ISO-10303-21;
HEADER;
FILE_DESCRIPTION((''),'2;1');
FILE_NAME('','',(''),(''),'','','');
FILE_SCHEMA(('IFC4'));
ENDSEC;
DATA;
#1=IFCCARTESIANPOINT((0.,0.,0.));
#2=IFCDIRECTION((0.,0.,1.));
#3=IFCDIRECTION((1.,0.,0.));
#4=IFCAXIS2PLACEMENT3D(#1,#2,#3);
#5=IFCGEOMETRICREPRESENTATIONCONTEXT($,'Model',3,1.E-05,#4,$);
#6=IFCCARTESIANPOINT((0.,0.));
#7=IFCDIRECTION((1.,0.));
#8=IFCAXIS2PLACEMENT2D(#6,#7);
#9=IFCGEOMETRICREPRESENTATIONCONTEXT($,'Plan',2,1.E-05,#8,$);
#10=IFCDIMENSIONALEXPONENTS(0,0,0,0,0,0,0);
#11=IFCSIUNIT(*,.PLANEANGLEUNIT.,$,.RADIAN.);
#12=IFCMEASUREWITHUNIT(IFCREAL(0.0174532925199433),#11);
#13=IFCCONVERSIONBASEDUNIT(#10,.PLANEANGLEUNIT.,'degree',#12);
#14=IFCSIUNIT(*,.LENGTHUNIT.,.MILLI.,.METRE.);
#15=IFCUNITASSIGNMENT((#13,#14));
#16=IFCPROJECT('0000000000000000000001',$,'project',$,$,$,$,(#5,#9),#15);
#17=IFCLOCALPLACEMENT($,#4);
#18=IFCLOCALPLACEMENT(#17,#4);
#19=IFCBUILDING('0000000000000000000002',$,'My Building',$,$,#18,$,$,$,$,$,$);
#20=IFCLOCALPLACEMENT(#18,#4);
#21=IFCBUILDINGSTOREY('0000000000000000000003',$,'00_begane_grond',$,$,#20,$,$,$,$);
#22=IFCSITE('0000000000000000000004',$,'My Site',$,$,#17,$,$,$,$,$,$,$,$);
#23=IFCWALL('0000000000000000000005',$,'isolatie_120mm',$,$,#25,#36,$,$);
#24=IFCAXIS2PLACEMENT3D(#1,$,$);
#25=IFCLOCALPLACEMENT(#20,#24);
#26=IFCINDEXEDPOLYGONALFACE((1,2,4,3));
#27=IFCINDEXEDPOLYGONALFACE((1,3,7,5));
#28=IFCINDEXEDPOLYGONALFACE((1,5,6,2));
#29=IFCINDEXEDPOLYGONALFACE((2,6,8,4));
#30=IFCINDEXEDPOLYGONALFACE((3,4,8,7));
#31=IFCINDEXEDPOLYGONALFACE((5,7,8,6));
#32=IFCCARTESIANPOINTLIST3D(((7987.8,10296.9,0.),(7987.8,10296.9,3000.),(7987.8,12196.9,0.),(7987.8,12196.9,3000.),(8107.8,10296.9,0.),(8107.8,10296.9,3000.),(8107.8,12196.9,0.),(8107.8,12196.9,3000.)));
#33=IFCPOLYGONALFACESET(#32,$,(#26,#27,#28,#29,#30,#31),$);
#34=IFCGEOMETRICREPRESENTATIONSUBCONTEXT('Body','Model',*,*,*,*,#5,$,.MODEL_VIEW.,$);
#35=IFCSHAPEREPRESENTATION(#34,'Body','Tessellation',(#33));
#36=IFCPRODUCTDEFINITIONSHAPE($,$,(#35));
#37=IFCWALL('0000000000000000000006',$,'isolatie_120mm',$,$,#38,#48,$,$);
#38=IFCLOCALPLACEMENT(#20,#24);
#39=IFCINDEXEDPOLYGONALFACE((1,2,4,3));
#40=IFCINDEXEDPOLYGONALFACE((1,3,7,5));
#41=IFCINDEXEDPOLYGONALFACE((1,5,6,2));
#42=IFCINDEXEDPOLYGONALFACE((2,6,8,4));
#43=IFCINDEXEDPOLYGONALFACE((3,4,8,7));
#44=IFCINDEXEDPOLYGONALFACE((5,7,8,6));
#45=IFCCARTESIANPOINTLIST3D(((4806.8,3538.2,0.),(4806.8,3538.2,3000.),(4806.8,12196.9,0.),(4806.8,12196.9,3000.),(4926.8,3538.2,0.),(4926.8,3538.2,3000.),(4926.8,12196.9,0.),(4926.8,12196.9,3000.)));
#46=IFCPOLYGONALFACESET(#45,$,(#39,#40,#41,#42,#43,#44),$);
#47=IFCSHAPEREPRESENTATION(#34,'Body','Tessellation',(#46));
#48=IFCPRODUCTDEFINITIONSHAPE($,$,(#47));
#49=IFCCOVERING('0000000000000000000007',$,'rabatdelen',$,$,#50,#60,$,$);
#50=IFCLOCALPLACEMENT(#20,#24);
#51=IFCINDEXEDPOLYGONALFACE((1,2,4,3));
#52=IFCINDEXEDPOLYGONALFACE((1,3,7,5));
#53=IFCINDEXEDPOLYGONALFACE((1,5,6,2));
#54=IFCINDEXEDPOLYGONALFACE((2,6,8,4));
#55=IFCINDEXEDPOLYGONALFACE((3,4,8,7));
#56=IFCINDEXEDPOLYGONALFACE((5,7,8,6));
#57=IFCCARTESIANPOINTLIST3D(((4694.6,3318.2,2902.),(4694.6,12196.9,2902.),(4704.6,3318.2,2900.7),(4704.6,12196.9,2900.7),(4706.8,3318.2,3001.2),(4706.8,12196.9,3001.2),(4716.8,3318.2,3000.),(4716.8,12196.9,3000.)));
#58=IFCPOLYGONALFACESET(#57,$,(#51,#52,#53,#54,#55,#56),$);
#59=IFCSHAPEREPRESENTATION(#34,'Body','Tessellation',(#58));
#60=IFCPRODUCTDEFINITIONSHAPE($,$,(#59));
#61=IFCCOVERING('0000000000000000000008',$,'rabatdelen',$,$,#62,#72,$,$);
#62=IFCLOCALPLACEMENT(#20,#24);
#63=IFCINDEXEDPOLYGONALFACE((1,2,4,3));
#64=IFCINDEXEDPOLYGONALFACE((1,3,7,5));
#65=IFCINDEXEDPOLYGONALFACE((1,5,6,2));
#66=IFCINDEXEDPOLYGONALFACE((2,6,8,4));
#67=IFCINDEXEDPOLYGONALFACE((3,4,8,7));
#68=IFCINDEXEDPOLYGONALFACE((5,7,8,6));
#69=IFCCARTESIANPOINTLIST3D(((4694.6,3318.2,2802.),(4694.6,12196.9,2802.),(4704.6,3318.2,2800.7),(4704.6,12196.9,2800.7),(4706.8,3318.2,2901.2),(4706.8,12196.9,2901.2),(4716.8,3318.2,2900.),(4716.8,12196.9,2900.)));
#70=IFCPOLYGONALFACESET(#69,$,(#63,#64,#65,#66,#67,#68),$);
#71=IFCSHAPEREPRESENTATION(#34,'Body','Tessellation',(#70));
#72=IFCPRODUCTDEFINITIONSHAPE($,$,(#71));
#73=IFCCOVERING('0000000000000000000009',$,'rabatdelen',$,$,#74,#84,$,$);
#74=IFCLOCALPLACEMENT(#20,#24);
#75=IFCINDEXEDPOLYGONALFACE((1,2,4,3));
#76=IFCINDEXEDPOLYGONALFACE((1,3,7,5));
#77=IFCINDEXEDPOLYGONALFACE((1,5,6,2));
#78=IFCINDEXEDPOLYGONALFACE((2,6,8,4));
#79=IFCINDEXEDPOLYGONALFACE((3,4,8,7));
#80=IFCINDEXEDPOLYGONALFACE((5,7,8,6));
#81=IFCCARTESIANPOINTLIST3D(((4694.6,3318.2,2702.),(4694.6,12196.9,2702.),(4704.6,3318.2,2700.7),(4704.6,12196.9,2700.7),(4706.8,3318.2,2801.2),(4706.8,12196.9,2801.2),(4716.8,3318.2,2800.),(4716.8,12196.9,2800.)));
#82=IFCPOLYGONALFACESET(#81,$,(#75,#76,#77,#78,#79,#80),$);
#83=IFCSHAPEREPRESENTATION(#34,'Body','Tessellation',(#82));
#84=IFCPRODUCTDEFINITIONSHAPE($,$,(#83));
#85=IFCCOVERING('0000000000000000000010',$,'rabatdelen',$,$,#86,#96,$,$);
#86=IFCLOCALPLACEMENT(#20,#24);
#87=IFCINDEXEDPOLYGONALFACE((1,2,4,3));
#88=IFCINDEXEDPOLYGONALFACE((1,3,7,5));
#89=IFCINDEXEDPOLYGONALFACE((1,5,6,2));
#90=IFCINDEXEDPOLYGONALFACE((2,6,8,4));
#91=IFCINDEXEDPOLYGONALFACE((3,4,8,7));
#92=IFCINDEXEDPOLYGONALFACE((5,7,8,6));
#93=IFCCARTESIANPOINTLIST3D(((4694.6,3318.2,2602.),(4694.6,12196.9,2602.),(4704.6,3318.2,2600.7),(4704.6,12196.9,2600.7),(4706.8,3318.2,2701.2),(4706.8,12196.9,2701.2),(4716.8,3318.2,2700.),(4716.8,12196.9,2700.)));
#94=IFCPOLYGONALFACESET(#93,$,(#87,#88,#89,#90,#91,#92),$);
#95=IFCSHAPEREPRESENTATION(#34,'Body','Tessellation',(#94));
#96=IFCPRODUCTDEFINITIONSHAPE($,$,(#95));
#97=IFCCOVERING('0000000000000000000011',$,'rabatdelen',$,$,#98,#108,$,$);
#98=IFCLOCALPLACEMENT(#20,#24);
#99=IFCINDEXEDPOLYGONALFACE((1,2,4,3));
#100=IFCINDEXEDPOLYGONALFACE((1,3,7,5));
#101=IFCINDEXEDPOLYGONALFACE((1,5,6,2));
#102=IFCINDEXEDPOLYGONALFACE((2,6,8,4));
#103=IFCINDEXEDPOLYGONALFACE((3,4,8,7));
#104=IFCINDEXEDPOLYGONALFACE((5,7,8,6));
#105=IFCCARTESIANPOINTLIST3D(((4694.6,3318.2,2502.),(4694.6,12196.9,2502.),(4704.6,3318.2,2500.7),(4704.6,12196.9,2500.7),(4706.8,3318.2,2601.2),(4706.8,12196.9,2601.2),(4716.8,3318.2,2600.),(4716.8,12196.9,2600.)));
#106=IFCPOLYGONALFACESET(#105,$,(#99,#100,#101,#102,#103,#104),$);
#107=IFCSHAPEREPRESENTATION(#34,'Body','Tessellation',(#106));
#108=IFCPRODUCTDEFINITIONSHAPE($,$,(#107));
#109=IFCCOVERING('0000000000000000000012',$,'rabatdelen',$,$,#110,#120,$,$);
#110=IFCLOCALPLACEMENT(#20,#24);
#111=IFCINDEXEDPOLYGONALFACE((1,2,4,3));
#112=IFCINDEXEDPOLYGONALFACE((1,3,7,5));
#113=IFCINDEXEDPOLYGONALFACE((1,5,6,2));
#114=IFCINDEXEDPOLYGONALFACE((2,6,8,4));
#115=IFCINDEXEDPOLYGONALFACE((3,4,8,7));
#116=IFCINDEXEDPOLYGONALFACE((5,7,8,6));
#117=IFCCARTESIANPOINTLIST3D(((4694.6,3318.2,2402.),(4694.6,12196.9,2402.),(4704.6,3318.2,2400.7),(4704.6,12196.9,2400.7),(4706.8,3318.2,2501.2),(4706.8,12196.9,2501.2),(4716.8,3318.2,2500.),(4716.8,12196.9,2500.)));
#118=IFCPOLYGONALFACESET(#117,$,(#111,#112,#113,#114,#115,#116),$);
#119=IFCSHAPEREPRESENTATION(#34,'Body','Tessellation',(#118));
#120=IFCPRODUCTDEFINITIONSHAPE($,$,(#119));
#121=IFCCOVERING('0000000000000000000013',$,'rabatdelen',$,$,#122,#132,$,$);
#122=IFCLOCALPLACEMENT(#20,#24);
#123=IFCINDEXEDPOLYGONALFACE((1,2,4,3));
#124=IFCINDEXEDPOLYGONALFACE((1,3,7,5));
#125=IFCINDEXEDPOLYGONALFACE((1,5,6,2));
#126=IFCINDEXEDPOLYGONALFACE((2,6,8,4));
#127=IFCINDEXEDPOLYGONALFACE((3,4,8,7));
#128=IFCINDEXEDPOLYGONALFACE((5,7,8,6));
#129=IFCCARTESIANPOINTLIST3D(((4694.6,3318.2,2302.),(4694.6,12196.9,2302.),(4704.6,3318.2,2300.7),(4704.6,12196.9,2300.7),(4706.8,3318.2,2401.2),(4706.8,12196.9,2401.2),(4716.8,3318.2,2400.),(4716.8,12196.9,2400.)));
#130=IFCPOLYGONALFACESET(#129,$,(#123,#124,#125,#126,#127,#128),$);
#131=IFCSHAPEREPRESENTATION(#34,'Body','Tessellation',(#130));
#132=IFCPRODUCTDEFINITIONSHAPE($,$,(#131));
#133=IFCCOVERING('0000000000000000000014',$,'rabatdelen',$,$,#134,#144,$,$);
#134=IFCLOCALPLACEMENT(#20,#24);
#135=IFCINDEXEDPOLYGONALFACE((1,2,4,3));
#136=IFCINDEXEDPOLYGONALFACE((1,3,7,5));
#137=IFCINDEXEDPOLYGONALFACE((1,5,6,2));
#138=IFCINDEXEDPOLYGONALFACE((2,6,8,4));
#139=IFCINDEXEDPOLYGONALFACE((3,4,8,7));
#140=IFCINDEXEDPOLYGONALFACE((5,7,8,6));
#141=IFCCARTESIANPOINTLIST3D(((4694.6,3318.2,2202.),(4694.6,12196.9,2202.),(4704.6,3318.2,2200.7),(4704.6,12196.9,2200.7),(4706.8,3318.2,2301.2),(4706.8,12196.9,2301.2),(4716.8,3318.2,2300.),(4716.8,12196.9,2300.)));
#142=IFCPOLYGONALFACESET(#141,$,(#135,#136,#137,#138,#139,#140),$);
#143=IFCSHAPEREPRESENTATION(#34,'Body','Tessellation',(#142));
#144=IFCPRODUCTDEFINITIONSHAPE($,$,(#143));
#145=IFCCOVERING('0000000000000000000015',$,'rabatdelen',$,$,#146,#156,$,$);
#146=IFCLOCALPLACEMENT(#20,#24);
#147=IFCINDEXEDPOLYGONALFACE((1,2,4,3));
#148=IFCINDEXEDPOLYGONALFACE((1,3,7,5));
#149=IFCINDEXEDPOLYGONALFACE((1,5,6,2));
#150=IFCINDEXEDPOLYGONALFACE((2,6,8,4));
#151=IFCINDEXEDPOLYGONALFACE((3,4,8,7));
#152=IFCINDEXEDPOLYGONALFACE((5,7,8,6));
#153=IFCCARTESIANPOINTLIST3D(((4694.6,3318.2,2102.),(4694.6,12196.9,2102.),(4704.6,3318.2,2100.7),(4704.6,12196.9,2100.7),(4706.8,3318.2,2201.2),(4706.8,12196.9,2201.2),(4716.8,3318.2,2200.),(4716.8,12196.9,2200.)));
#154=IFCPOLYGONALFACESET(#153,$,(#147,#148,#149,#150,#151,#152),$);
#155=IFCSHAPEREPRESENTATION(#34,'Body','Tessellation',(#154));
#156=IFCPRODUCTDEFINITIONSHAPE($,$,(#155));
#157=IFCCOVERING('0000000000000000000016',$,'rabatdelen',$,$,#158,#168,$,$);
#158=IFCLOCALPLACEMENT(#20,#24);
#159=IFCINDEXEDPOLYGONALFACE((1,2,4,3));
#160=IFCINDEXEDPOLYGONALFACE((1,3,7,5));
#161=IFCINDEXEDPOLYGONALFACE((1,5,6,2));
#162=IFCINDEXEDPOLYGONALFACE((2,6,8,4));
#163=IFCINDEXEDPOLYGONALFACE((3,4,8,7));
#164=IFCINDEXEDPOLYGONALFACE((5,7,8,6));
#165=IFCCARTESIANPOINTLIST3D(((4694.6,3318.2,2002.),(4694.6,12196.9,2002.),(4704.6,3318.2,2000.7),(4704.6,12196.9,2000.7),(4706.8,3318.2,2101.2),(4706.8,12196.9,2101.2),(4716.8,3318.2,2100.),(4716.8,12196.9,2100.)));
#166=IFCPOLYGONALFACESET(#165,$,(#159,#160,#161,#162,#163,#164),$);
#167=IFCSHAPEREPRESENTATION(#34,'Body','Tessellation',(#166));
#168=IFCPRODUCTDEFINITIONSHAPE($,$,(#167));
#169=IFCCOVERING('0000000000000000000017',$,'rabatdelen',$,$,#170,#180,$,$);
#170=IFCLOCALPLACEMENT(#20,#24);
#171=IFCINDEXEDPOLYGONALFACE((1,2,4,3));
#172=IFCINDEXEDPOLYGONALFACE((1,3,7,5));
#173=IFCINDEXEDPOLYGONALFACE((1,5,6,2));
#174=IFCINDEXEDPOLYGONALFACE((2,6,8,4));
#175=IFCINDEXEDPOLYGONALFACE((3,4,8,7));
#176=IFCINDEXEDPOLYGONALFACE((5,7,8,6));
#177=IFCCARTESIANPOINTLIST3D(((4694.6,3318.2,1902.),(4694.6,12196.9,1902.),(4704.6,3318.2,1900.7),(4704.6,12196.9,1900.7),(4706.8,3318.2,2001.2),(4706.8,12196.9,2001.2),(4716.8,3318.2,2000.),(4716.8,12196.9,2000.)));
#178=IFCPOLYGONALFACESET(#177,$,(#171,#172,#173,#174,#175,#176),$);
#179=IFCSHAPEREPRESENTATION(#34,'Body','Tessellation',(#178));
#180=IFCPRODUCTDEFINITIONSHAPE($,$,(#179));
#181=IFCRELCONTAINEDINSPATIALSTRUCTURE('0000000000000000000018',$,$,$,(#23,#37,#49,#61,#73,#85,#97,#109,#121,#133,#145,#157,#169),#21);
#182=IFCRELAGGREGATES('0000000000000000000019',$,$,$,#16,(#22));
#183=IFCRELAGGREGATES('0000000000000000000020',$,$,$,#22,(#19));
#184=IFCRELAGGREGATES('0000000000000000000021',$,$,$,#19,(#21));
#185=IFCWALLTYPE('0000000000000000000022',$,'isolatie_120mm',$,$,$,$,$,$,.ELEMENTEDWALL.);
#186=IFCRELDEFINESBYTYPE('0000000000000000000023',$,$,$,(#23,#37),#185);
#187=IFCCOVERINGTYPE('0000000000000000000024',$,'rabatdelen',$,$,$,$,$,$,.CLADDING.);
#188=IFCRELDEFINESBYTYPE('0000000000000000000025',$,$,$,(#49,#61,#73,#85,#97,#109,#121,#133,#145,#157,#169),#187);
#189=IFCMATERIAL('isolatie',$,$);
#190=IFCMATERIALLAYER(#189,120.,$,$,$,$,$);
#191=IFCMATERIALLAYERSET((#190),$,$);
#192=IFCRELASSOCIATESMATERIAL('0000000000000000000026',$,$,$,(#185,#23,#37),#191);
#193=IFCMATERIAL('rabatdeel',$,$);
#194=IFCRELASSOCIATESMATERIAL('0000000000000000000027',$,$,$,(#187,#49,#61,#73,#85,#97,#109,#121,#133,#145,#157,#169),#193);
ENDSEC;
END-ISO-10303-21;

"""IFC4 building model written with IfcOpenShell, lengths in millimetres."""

from ifc_helpers import new_model, entity, si_unit, converted_unit, frame, origin_with_axes, origin_2d_with_axis, place, context, subcontext, project, spatial, indexed_curve, rectangle, outline, extrude, material, layer, layer_set, layer_usage, material_profile, profile_set, profile_usage, type_object, element, save


model = new_model("IFC4")

# Units and contexts
model_context = context("Model", 3, precision=1e-05, world=origin_with_axes())
plan_context = context("Plan", 2, precision=1e-05, world=origin_2d_with_axis())
body_context = subcontext(model_context, "Body", "Model", "MODEL_VIEW")
ifc_project = project(units=[converted_unit("PLANEANGLEUNIT", "degree", entity("IfcReal", 0.0174532925199433), si_unit("PLANEANGLEUNIT", "RADIAN"), dimensions=[0, 0, 0, 0, 0, 0, 0]), si_unit("LENGTHUNIT", "METRE", prefix="MILLI")], contexts=[model_context, plan_context])

# Site, building, storey
site_placement = place(None, origin_with_axes())
site = spatial("IfcSite", under=ifc_project, at=site_placement, Name="My Site")
building_placement = place(site_placement, origin_with_axes())
building = spatial("IfcBuilding", under=site, at=building_placement, Name="My Building")
storey_placement = place(building_placement, origin_with_axes())
storey = spatial("IfcBuildingStorey", under=building, at=storey_placement, Name="00_begane_grond")

# Walls
ifc_material_1 = material(Name="isolatie")
ifc_layer = layer(ifc_material_1, 120.0)
ifc_layer_set = layer_set([ifc_layer])
ifc_layer_usage_1 = layer_usage(ifc_layer_set, "AXIS2", "POSITIVE", 0.0)
wall_type = type_object("IfcWallType", Name="isolatie_120mm", PredefinedType="ELEMENTEDWALL", material=ifc_layer_set)
wall_1_placement = place(storey_placement, frame((7987.8, 12196.9, 0.0), z_axis=(0.0, 0.0, 1.0), x_axis=(-0.000001, -1.0, 0.0)))
element("IfcWall", 1, at=wall_1_placement, inside=storey, type_object=wall_type, material=ifc_layer_usage_1, Name="isolatie_120mm", context=body_context, shape_type="SweptSolid", body=[
    extrude(outline(indexed_curve([(0.0, 0.0), (0.0, 120.0), (1900.0, 120.0), (1900.0, 0.0), (0.0, 0.0)], self_intersect=False)), origin_with_axes(), (0.0, 0.0, 1.0), 3000.0),
])
ifc_layer_usage_2 = layer_usage(ifc_layer_set, "AXIS2", "POSITIVE", 0.0)
wall_2_placement = place(storey_placement, frame((4806.8, 12196.9, 0.0), z_axis=(0.0, 0.0, 1.0), x_axis=(0.0, -1.0, 0.0)))
element("IfcWall", 2, at=wall_2_placement, inside=storey, type_object=wall_type, material=ifc_layer_usage_2, Name="isolatie_120mm", context=body_context, shape_type="SweptSolid", body=[
    extrude(outline(indexed_curve([(0.0, 0.0), (0.0, 120.0), (8658.8, 120.0), (8658.8, 0.0), (0.0, 0.0)], self_intersect=False)), origin_with_axes(), (0.0, 0.0, 1.0), 3000.0),
])

# Coverings
ifc_material_2 = material(Name="rabatdeel")
ifc_material_profile = material_profile(ifc_material_2, rectangle(XDim=10.0, YDim=100.0))
ifc_profile_set = profile_set([ifc_material_profile])
ifc_profile_usage_1 = profile_usage(ifc_profile_set, cardinal=7)
covering_type = type_object("IfcCoveringType", Name="rabatdelen", PredefinedType="CLADDING", material=ifc_profile_set)
covering_1_placement = place(storey_placement, frame((4716.8, 12196.9, 3000.0), z_axis=(0.0, -1.0, 0.0), x_axis=(0.992546, 0.0, -0.121869)))
element("IfcCovering", 3, at=covering_1_placement, inside=storey, type_object=covering_type, material=ifc_profile_usage_1, Name="rabatdelen", context=body_context, shape_type="SweptSolid", body=[
    extrude(rectangle(XDim=10.0, YDim=100.0), frame((-5.0, -50.0, 0.0), z_axis=(0.0, 0.0, 1.0), x_axis=(1.0, 0.0, 0.0)), (0.0, 0.0, 1.0), 8878.8),
])
ifc_profile_usage_2 = profile_usage(ifc_profile_set, cardinal=7)
covering_2_placement = place(storey_placement, frame((4716.8, 12196.9, 2900.0), z_axis=(0.0, -1.0, 0.0), x_axis=(0.992546, 0.0, -0.121869)))
element("IfcCovering", 4, at=covering_2_placement, inside=storey, type_object=covering_type, material=ifc_profile_usage_2, Name="rabatdelen", context=body_context, shape_type="SweptSolid", body=[
    extrude(rectangle(XDim=10.0, YDim=100.0), frame((-5.0, -50.0, 0.0), z_axis=(0.0, 0.0, 1.0), x_axis=(1.0, 0.0, 0.0)), (0.0, 0.0, 1.0), 8878.8),
])
ifc_profile_usage_3 = profile_usage(ifc_profile_set, cardinal=7)
covering_3_placement = place(storey_placement, frame((4716.8, 12196.9, 2800.0), z_axis=(0.0, -1.0, 0.0), x_axis=(0.992546, 0.0, -0.121869)))
element("IfcCovering", 5, at=covering_3_placement, inside=storey, type_object=covering_type, material=ifc_profile_usage_3, Name="rabatdelen", context=body_context, shape_type="SweptSolid", body=[
    extrude(rectangle(XDim=10.0, YDim=100.0), frame((-5.0, -50.0, 0.0), z_axis=(0.0, 0.0, 1.0), x_axis=(1.0, 0.0, 0.0)), (0.0, 0.0, 1.0), 8878.8),
])
ifc_profile_usage_4 = profile_usage(ifc_profile_set, cardinal=7)
covering_4_placement = place(storey_placement, frame((4716.8, 12196.9, 2700.0), z_axis=(0.0, -1.0, 0.0), x_axis=(0.992546, 0.0, -0.121869)))
element("IfcCovering", 6, at=covering_4_placement, inside=storey, type_object=covering_type, material=ifc_profile_usage_4, Name="rabatdelen", context=body_context, shape_type="SweptSolid", body=[
    extrude(rectangle(XDim=10.0, YDim=100.0), frame((-5.0, -50.0, 0.0), z_axis=(0.0, 0.0, 1.0), x_axis=(1.0, 0.0, 0.0)), (0.0, 0.0, 1.0), 8878.8),
])
ifc_profile_usage_5 = profile_usage(ifc_profile_set, cardinal=7)
covering_5_placement = place(storey_placement, frame((4716.8, 12196.9, 2600.0), z_axis=(0.0, -1.0, 0.0), x_axis=(0.992546, 0.0, -0.121869)))
element("IfcCovering", 7, at=covering_5_placement, inside=storey, type_object=covering_type, material=ifc_profile_usage_5, Name="rabatdelen", context=body_context, shape_type="SweptSolid", body=[
    extrude(rectangle(XDim=10.0, YDim=100.0), frame((-5.0, -50.0, 0.0), z_axis=(0.0, 0.0, 1.0), x_axis=(1.0, 0.0, 0.0)), (0.0, 0.0, 1.0), 8878.8),
])
ifc_profile_usage_6 = profile_usage(ifc_profile_set, cardinal=7)
covering_6_placement = place(storey_placement, frame((4716.8, 12196.9, 2500.0), z_axis=(0.0, -1.0, 0.0), x_axis=(0.992546, 0.0, -0.121869)))
element("IfcCovering", 8, at=covering_6_placement, inside=storey, type_object=covering_type, material=ifc_profile_usage_6, Name="rabatdelen", context=body_context, shape_type="SweptSolid", body=[
    extrude(rectangle(XDim=10.0, YDim=100.0), frame((-5.0, -50.0, 0.0), z_axis=(0.0, 0.0, 1.0), x_axis=(1.0, 0.0, 0.0)), (0.0, 0.0, 1.0), 8878.8),
])
ifc_profile_usage_7 = profile_usage(ifc_profile_set, cardinal=7)
covering_7_placement = place(storey_placement, frame((4716.8, 12196.9, 2400.0), z_axis=(0.0, -1.0, 0.0), x_axis=(0.992546, 0.0, -0.121869)))
element("IfcCovering", 9, at=covering_7_placement, inside=storey, type_object=covering_type, material=ifc_profile_usage_7, Name="rabatdelen", context=body_context, shape_type="SweptSolid", body=[
    extrude(rectangle(XDim=10.0, YDim=100.0), frame((-5.0, -50.0, 0.0), z_axis=(0.0, 0.0, 1.0), x_axis=(1.0, 0.0, 0.0)), (0.0, 0.0, 1.0), 8878.8),
])
ifc_profile_usage_8 = profile_usage(ifc_profile_set, cardinal=7)
covering_8_placement = place(storey_placement, frame((4716.8, 12196.9, 2300.0), z_axis=(0.0, -1.0, 0.0), x_axis=(0.992546, 0.0, -0.121869)))
element("IfcCovering", 10, at=covering_8_placement, inside=storey, type_object=covering_type, material=ifc_profile_usage_8, Name="rabatdelen", context=body_context, shape_type="SweptSolid", body=[
    extrude(rectangle(XDim=10.0, YDim=100.0), frame((-5.0, -50.0, 0.0), z_axis=(0.0, 0.0, 1.0), x_axis=(1.0, 0.0, 0.0)), (0.0, 0.0, 1.0), 8878.8),
])
ifc_profile_usage_9 = profile_usage(ifc_profile_set, cardinal=7)
covering_9_placement = place(storey_placement, frame((4716.8, 12196.9, 2200.0), z_axis=(0.0, -1.0, 0.0), x_axis=(0.992546, 0.0, -0.121869)))
element("IfcCovering", 11, at=covering_9_placement, inside=storey, type_object=covering_type, material=ifc_profile_usage_9, Name="rabatdelen", context=body_context, shape_type="SweptSolid", body=[
    extrude(rectangle(XDim=10.0, YDim=100.0), frame((-5.0, -50.0, 0.0), z_axis=(0.0, 0.0, 1.0), x_axis=(1.0, 0.0, 0.0)), (0.0, 0.0, 1.0), 8878.8),
])
ifc_profile_usage_10 = profile_usage(ifc_profile_set, cardinal=7)
covering_10_placement = place(storey_placement, frame((4716.8, 12196.9, 2100.0), z_axis=(0.0, -1.0, 0.0), x_axis=(0.992546, 0.0, -0.121869)))
element("IfcCovering", 12, at=covering_10_placement, inside=storey, type_object=covering_type, material=ifc_profile_usage_10, Name="rabatdelen", context=body_context, shape_type="SweptSolid", body=[
    extrude(rectangle(XDim=10.0, YDim=100.0), frame((-5.0, -50.0, 0.0), z_axis=(0.0, 0.0, 1.0), x_axis=(1.0, 0.0, 0.0)), (0.0, 0.0, 1.0), 8878.8),
])
ifc_profile_usage_11 = profile_usage(ifc_profile_set, cardinal=7)
covering_11_placement = place(storey_placement, frame((4716.8, 12196.9, 2000.0), z_axis=(0.0, -1.0, 0.0), x_axis=(0.992546, 0.0, -0.121869)))
element("IfcCovering", 13, at=covering_11_placement, inside=storey, type_object=covering_type, material=ifc_profile_usage_11, Name="rabatdelen", context=body_context, shape_type="SweptSolid", body=[
    extrude(rectangle(XDim=10.0, YDim=100.0), frame((-5.0, -50.0, 0.0), z_axis=(0.0, 0.0, 1.0), x_axis=(1.0, 0.0, 0.0)), (0.0, 0.0, 1.0), 8878.8),
])

save(model, "model.ifc")
